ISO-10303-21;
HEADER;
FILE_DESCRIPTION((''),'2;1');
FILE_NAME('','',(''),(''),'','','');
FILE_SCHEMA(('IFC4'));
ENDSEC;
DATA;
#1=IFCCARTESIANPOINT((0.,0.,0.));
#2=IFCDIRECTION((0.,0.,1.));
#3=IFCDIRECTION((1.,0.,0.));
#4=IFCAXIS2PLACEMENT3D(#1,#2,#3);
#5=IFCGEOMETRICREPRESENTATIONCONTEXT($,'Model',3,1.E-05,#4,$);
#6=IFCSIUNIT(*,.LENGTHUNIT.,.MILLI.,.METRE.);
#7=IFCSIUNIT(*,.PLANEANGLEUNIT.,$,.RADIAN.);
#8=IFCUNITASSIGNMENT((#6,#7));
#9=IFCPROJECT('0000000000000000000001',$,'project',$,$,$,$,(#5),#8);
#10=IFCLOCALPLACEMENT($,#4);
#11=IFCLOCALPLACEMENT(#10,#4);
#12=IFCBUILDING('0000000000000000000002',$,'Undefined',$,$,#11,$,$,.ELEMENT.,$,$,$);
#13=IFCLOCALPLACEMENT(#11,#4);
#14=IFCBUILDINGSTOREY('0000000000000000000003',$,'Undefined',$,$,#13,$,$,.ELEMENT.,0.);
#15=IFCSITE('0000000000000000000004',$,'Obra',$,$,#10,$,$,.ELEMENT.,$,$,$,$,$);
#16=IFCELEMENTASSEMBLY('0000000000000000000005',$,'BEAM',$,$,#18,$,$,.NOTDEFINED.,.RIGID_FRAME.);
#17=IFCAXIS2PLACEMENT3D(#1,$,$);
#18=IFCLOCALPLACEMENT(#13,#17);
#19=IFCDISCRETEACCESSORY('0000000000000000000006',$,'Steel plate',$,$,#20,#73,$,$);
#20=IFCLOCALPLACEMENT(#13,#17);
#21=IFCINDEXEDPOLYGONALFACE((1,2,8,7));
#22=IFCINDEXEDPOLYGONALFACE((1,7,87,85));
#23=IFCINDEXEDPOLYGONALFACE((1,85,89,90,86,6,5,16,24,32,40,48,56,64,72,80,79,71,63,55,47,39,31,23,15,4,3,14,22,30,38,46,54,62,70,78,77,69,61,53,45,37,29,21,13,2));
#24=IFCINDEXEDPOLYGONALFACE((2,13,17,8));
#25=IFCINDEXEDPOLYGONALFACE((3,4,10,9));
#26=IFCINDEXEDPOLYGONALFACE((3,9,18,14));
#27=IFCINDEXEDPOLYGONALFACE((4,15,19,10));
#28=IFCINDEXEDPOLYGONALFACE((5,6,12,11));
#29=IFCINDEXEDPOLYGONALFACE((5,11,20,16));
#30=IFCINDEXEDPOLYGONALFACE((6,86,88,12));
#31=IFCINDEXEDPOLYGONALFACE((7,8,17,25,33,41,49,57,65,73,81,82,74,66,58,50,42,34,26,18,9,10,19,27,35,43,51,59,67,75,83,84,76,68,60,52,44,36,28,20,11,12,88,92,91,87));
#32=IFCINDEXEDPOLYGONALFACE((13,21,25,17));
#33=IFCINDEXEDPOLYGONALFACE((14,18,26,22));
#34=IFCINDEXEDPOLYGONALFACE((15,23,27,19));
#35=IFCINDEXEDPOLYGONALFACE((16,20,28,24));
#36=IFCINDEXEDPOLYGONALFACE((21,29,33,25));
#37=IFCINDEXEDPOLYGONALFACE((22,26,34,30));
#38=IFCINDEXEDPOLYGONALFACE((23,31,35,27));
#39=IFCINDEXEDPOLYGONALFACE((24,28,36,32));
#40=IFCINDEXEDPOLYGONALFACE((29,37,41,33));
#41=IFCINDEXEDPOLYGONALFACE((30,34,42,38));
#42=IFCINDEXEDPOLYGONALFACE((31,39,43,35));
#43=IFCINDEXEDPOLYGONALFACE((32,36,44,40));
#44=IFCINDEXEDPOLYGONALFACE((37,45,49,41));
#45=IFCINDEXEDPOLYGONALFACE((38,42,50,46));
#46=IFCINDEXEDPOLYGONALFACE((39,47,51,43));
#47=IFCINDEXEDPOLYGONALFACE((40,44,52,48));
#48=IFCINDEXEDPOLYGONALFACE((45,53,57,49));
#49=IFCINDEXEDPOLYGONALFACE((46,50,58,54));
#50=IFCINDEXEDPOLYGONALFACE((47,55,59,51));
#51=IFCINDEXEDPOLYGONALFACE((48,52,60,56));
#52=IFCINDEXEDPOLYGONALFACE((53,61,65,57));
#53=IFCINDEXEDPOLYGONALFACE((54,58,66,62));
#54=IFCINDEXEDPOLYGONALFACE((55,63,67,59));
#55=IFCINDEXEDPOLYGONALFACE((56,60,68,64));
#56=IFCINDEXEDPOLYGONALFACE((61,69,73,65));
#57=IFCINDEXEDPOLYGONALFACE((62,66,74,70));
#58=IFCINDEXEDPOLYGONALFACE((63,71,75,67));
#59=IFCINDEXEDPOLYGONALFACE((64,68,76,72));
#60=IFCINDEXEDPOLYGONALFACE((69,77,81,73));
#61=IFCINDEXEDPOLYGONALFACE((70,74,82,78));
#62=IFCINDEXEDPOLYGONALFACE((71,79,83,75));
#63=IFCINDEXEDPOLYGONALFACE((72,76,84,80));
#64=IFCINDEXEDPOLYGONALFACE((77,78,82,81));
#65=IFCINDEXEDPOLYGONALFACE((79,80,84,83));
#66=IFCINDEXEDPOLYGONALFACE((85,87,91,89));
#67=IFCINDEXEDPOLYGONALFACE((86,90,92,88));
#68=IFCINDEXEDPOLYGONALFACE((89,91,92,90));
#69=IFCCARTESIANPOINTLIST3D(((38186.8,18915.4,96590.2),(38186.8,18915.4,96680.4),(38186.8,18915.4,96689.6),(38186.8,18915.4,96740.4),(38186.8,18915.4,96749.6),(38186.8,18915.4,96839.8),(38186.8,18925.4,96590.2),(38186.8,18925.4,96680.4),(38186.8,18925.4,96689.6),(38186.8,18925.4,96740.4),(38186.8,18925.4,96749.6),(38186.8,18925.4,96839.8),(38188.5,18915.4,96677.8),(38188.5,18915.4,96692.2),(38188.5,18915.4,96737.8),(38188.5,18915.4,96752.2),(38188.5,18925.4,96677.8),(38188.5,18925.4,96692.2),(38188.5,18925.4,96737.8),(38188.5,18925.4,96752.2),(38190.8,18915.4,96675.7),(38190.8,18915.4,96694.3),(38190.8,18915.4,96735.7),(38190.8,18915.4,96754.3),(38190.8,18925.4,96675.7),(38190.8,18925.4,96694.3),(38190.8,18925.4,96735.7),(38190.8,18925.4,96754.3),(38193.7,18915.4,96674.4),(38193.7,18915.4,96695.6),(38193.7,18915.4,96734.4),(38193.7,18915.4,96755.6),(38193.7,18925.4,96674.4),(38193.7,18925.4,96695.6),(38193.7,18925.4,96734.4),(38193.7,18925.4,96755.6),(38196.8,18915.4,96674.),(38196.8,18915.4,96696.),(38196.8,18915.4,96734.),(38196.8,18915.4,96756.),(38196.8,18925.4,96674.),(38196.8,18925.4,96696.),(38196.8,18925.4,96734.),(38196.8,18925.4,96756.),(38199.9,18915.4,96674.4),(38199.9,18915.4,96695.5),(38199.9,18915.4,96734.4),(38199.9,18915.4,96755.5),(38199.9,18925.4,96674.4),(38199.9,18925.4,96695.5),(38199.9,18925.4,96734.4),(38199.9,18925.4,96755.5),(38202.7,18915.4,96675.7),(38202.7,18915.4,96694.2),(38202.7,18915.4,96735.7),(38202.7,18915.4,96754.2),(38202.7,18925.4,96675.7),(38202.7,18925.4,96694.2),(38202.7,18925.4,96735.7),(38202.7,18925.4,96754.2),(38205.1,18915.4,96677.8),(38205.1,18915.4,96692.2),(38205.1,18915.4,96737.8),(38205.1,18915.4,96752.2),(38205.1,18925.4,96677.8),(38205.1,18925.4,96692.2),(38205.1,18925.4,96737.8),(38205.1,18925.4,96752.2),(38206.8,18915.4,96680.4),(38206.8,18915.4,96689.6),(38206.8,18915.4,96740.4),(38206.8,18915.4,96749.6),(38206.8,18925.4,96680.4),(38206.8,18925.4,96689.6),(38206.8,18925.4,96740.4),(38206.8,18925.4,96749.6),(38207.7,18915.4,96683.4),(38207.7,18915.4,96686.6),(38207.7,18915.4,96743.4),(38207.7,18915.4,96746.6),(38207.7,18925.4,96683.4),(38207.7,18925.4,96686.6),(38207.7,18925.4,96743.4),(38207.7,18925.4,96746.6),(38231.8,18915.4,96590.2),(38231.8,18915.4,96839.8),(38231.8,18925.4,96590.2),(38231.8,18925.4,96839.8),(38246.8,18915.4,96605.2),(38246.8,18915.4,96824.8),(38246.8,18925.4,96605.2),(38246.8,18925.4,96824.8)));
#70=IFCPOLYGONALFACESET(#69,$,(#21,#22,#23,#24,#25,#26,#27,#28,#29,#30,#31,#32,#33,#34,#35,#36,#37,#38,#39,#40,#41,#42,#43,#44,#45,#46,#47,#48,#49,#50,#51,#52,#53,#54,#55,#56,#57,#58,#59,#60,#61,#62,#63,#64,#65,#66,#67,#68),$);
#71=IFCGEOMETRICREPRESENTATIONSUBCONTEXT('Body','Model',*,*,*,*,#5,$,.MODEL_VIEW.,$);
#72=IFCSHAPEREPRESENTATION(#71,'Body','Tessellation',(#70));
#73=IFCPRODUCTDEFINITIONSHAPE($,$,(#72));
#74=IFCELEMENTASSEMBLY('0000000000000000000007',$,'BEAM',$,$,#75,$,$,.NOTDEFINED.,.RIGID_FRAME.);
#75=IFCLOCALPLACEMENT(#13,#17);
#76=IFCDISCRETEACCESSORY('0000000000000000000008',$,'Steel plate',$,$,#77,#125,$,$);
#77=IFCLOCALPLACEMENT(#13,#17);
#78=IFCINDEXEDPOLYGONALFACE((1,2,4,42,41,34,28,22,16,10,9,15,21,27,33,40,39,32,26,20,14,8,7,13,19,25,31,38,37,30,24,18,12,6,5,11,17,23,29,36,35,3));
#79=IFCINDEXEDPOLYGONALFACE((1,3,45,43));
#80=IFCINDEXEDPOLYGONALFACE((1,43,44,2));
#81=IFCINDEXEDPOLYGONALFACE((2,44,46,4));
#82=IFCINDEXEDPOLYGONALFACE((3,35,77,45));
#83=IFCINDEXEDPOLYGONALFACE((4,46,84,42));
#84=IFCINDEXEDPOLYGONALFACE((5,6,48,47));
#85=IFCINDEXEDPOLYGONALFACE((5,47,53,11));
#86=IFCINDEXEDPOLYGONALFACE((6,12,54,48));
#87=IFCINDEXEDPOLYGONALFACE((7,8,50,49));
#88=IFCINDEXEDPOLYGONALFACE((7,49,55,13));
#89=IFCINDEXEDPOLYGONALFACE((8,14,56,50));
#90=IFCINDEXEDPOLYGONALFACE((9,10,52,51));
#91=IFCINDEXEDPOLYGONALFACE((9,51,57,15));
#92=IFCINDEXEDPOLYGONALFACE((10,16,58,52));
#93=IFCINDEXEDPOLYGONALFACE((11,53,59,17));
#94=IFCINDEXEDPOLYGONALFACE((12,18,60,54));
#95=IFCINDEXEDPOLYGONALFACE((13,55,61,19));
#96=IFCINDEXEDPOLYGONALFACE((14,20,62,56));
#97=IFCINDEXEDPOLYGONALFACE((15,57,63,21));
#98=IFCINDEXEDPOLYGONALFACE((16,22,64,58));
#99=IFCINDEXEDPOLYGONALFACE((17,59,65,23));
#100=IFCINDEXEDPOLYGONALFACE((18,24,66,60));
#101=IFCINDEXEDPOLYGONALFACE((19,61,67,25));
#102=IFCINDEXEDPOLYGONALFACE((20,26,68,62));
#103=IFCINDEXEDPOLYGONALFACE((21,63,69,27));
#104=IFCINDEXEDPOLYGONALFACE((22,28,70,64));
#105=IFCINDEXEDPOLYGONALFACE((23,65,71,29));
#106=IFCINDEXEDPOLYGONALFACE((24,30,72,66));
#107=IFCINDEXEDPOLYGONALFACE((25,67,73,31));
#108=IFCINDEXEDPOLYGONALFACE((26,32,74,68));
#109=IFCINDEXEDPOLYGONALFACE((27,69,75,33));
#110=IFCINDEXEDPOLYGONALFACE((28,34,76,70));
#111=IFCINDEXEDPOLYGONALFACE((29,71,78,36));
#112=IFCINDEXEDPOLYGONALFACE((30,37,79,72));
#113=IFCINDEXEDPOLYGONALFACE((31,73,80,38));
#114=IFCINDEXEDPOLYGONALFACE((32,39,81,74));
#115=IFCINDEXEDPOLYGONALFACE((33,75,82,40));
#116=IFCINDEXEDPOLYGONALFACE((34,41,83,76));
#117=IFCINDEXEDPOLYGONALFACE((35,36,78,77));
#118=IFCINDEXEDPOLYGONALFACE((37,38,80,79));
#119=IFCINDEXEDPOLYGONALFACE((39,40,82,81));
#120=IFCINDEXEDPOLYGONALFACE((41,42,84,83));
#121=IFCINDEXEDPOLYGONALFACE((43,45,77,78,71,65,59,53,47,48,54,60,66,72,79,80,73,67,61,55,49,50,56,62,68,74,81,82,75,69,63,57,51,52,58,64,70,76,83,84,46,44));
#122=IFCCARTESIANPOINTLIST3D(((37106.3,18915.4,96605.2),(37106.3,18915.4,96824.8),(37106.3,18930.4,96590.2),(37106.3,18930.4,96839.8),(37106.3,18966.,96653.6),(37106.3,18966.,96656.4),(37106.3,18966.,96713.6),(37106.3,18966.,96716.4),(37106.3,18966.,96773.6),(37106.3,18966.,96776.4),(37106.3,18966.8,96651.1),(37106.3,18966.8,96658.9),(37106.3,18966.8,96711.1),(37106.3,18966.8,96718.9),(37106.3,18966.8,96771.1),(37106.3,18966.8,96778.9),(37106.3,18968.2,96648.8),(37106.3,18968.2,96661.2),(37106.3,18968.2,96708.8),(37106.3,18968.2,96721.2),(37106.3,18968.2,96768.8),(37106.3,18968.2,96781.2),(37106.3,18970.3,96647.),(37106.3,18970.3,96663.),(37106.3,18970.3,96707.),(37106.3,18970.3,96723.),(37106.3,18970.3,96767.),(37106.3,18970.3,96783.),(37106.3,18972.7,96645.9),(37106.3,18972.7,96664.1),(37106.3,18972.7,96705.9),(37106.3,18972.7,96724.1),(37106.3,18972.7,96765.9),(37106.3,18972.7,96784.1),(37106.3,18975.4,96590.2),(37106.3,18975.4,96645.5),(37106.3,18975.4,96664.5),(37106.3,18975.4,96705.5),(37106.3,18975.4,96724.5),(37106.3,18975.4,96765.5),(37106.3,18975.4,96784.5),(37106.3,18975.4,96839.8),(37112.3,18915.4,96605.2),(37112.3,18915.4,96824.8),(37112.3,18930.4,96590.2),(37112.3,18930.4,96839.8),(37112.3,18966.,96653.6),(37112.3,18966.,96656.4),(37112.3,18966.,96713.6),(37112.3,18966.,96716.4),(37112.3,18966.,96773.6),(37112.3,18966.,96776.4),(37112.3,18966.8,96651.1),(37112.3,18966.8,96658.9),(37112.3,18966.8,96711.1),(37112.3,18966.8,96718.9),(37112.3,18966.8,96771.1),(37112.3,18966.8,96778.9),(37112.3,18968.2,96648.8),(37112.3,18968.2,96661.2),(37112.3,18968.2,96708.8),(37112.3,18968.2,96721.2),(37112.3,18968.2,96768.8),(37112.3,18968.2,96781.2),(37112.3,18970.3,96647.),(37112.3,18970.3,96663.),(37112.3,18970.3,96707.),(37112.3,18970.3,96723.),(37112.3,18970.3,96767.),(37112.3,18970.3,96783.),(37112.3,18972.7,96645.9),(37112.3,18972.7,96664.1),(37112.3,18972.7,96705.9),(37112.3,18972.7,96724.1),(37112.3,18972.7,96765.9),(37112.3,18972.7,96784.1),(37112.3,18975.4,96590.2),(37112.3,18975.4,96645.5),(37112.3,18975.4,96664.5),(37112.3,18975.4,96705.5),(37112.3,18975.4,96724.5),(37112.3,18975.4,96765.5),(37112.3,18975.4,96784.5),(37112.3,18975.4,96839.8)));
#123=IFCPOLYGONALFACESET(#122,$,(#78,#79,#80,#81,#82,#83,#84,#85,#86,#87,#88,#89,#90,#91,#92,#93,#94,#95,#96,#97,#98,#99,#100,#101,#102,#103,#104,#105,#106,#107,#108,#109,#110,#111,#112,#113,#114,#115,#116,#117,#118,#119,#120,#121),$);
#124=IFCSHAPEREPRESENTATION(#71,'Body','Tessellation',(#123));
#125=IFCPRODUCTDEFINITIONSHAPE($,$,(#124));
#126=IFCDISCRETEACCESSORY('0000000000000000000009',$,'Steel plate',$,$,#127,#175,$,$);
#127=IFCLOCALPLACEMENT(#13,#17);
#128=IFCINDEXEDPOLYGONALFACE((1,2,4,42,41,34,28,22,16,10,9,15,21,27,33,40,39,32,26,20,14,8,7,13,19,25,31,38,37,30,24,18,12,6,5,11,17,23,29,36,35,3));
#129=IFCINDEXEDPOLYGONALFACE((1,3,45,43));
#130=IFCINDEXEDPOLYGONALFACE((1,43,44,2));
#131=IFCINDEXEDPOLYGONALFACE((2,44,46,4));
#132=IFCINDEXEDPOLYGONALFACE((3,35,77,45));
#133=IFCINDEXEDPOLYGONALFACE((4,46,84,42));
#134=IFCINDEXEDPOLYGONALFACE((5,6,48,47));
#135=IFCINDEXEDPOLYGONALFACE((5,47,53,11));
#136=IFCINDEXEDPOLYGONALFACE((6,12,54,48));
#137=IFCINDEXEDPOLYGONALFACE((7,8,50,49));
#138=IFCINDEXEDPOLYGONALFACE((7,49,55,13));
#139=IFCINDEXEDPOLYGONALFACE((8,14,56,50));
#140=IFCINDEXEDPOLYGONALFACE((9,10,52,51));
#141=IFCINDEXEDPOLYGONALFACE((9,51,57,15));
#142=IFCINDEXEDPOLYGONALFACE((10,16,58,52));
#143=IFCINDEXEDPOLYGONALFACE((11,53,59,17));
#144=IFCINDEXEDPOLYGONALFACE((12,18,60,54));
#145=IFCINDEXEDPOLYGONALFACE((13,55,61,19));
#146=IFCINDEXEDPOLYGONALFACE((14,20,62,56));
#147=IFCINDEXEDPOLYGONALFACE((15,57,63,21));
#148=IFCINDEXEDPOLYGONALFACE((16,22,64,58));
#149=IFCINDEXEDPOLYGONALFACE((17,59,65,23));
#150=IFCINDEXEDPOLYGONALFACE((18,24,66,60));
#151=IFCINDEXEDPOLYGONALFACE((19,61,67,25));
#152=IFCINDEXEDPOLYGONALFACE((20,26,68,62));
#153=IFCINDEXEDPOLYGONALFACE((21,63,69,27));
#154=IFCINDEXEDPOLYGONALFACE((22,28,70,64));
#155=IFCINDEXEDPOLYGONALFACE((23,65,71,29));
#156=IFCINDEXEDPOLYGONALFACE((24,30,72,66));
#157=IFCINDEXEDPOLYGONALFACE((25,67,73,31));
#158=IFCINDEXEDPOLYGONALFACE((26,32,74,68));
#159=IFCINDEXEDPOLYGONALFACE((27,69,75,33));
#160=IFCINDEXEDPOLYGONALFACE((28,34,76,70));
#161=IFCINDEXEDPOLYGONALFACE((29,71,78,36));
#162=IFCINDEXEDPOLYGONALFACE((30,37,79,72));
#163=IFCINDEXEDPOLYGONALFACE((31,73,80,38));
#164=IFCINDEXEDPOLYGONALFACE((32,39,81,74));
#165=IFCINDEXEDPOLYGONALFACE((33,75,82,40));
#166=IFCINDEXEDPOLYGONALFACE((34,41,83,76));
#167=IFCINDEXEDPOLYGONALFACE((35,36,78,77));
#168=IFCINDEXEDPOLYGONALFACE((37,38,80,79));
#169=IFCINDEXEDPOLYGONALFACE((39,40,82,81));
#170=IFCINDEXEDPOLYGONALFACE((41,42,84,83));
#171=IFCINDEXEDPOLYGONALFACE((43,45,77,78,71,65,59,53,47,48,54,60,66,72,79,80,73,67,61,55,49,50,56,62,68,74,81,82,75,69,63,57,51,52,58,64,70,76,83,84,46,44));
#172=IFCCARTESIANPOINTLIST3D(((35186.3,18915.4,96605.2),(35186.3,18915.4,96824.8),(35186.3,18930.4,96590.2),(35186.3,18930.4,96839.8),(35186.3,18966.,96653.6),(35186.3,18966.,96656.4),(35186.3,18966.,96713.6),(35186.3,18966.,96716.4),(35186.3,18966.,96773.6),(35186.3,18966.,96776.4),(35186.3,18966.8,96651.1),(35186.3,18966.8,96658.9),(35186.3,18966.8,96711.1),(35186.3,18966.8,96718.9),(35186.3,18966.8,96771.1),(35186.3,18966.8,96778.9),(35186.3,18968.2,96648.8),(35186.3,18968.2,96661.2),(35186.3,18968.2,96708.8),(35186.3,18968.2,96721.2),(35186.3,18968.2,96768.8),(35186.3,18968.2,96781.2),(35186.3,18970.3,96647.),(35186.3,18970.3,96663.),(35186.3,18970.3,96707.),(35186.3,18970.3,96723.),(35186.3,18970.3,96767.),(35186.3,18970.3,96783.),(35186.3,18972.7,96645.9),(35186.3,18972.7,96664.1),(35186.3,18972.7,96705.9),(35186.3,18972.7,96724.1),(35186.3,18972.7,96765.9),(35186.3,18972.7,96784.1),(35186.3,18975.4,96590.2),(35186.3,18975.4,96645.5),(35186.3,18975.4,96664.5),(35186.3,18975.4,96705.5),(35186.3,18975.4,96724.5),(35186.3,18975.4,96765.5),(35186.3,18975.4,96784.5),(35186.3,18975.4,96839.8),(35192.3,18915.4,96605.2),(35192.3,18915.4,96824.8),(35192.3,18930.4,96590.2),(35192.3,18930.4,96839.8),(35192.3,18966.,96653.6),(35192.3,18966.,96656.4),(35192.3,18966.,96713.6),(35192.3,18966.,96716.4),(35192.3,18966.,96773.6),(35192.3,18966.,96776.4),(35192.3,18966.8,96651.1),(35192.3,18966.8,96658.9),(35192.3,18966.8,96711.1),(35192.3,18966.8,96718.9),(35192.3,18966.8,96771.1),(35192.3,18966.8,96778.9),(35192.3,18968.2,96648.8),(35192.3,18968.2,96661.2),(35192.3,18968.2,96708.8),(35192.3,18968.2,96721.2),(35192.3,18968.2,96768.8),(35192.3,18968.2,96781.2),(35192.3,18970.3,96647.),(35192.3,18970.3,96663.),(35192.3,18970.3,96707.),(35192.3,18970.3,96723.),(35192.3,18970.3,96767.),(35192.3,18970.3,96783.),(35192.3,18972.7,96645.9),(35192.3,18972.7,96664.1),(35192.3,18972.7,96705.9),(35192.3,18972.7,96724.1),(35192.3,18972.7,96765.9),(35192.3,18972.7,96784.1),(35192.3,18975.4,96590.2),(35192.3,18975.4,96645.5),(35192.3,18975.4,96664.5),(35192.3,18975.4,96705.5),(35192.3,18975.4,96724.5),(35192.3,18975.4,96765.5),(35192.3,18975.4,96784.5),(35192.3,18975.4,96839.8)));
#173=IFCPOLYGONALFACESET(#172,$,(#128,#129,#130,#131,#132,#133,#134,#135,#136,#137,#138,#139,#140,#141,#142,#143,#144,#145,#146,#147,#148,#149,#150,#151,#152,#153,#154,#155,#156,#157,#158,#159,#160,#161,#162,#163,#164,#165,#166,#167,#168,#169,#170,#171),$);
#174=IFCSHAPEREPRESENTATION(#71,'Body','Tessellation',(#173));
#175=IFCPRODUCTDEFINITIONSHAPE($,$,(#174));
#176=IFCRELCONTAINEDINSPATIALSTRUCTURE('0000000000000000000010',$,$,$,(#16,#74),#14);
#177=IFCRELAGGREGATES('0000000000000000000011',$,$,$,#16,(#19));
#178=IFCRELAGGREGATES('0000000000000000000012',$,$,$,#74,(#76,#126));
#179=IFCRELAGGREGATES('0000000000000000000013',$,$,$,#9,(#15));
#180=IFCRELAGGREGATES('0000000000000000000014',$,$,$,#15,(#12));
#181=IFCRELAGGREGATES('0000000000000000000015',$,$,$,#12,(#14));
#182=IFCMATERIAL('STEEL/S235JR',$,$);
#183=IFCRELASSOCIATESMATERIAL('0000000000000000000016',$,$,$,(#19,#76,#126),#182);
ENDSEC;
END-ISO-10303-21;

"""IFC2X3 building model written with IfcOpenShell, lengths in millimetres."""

from ifc_helpers import new_model, si_unit, frame, origin_with_axes, origin_2d_with_axis, place, context, subcontext, project, spatial, polyline, circle, outline, extrude, source, transform, mapped, material, element, aggregate, save


model = new_model("IFC2X3")

# Units and contexts
model_context = context("Model", 3, precision=1e-05, world=origin_with_axes())
body_context = subcontext(model_context, "Body", "Model", "MODEL_VIEW")
ifc_project = project(units=[si_unit("LENGTHUNIT", "METRE", prefix="MILLI"), si_unit("PLANEANGLEUNIT", "RADIAN")], contexts=[model_context])

# Site, building, storey
site_placement = place(None, origin_with_axes())
site = spatial("IfcSite", under=ifc_project, at=site_placement, Name="Obra", CompositionType="ELEMENT")
building_placement = place(site_placement, origin_with_axes())
building = spatial("IfcBuilding", under=site, at=building_placement, Name="Undefined", CompositionType="ELEMENT")
storey_placement = place(building_placement, origin_with_axes())
storey = spatial("IfcBuildingStorey", under=building, at=storey_placement, Name="Undefined", CompositionType="ELEMENT", Elevation=0.0)

# Shared definitions
ifc_material = material(Name="STEEL/S235JR")

# Element assembly
assembly_1_placement = place(storey_placement, origin_with_axes())
assembly_1 = element("IfcElementAssembly", 1, at=assembly_1_placement, inside=storey, Name="BEAM", AssemblyPlace="NOTDEFINED", PredefinedType="RIGID_FRAME")

# Shared definitions
shared_shape_1 = source(origin_with_axes(), body_context, "Body", "SweptSolid", [
    extrude(circle(Radius=9.5, at=origin_2d_with_axis()), frame((0.0, -9.4, 0.0), z_axis=(0.0, 1.0, 0.0), x_axis=(1.0, 0.0, 0.0)), (0.0, 0.0, 1.0), 6.2),
])

# Discrete accessory, opening
shared_shape_2 = source(origin_with_axes(), body_context, "Body", "SweptSolid", [
    extrude(circle(Radius=11.0, at=origin_2d_with_axis()), frame((0.0, -13.4, 0.0), z_axis=(0.0, 1.0, 0.0), x_axis=(1.0, 0.0, 0.0)), (0.0, 0.0, 1.0), 10.2),
])
discrete_accessory_1_placement = place(assembly_1_placement, frame((38186.8, 18920.4, 96590.2), z_axis=(0.0, -1.0, 0.0), x_axis=(1.0, 0.0, 0.0)))
discrete_accessory_1 = element("IfcDiscreteAccessory", 2, at=discrete_accessory_1_placement, material=ifc_material, Name="Steel plate", context=body_context, shape_type="SweptSolid", body=[
    extrude(outline(polyline([(0.0, 0.0), (45.0, 0.0), (60.0, 15.0), (60.0, 234.6), (45.0, 249.6), (0.0, 249.6), (0.0, 0.0)])), frame((0.0, 0.0, -5.0), z_axis=(0.0, 0.0, 1.0), x_axis=(1.0, 0.0, 0.0)), (0.0, 0.0, 1.0), 10.0),
])
opening_1_placement = place(assembly_1_placement, frame((38236.8, 18912.1, 96850.0), z_axis=(-1.0, 0.0, 0.0), x_axis=(0.0, 0.0, -1.0)))
element("IfcOpeningElement", 3, at=opening_1_placement, cuts=discrete_accessory_1, ObjectType="Opening", context=body_context, shape_type="MappedRepresentation", body=[
    mapped(shared_shape_2, transform((105.0, 0.0, 40.0))),
    mapped(shared_shape_2, transform((165.0, 0.0, 40.0))),
])
aggregate(assembly_1, [discrete_accessory_1])

# Element assembly, discrete accessories, openings
assembly_2_placement = place(storey_placement, origin_with_axes())
assembly_2 = element("IfcElementAssembly", 4, at=assembly_2_placement, inside=storey, Name="BEAM", AssemblyPlace="NOTDEFINED", PredefinedType="RIGID_FRAME")
discrete_accessory_2_placement = place(assembly_2_placement, frame((37109.3, 18975.4, 96590.2), z_axis=(-1.0, 0.0, 0.0), x_axis=(0.0, -1.0, 0.0)))
discrete_accessory_2 = element("IfcDiscreteAccessory", 5, at=discrete_accessory_2_placement, material=ifc_material, Name="Steel plate", context=body_context, shape_type="SweptSolid", body=[
    extrude(outline(polyline([(0.0, 0.0), (45.0, 0.0), (60.0, 15.0), (60.0, 234.6), (45.0, 249.6), (0.0, 249.6), (0.0, 0.0)])), frame((0.0, 0.0, -3.0), z_axis=(0.0, 0.0, 1.0), x_axis=(1.0, 0.0, 0.0)), (0.0, 0.0, 1.0), 6.0),
])
opening_2_placement = place(assembly_2_placement, frame((37103.0, 18925.4, 96850.0), z_axis=(0.0, 1.0, 0.0), x_axis=(0.0, 0.0, -1.0)))
element("IfcOpeningElement", 6, at=opening_2_placement, cuts=discrete_accessory_2, ObjectType="Opening", context=body_context, shape_type="MappedRepresentation", body=[
    mapped(shared_shape_1, transform((75.0, 0.0, 50.0))),
    mapped(shared_shape_1, transform((135.0, 0.0, 50.0))),
    mapped(shared_shape_1, transform((195.0, 0.0, 50.0))),
])
discrete_accessory_3_placement = place(assembly_2_placement, frame((35189.3, 18975.4, 96590.2), z_axis=(-1.0, 0.0, 0.0), x_axis=(0.0, -1.0, 0.0)))
discrete_accessory_3 = element("IfcDiscreteAccessory", 7, at=discrete_accessory_3_placement, material=ifc_material, Name="Steel plate", context=body_context, shape_type="SweptSolid", body=[
    extrude(outline(polyline([(0.0, 0.0), (45.0, 0.0), (60.0, 15.0), (60.0, 234.6), (45.0, 249.6), (0.0, 249.6), (0.0, 0.0)])), frame((0.0, 0.0, -3.0), z_axis=(0.0, 0.0, 1.0), x_axis=(1.0, 0.0, 0.0)), (0.0, 0.0, 1.0), 6.0),
])
opening_3_placement = place(assembly_2_placement, frame((35183.0, 18925.4, 96850.0), z_axis=(0.0, 1.0, 0.0), x_axis=(0.0, 0.0, -1.0)))
element("IfcOpeningElement", 8, at=opening_3_placement, cuts=discrete_accessory_3, ObjectType="Opening", context=body_context, shape_type="MappedRepresentation", body=[
    mapped(shared_shape_1, transform((75.0, 0.0, 50.0))),
    mapped(shared_shape_1, transform((135.0, 0.0, 50.0))),
    mapped(shared_shape_1, transform((195.0, 0.0, 50.0))),
])
aggregate(assembly_2, [discrete_accessory_2, discrete_accessory_3])

save(model, "model.ifc")
